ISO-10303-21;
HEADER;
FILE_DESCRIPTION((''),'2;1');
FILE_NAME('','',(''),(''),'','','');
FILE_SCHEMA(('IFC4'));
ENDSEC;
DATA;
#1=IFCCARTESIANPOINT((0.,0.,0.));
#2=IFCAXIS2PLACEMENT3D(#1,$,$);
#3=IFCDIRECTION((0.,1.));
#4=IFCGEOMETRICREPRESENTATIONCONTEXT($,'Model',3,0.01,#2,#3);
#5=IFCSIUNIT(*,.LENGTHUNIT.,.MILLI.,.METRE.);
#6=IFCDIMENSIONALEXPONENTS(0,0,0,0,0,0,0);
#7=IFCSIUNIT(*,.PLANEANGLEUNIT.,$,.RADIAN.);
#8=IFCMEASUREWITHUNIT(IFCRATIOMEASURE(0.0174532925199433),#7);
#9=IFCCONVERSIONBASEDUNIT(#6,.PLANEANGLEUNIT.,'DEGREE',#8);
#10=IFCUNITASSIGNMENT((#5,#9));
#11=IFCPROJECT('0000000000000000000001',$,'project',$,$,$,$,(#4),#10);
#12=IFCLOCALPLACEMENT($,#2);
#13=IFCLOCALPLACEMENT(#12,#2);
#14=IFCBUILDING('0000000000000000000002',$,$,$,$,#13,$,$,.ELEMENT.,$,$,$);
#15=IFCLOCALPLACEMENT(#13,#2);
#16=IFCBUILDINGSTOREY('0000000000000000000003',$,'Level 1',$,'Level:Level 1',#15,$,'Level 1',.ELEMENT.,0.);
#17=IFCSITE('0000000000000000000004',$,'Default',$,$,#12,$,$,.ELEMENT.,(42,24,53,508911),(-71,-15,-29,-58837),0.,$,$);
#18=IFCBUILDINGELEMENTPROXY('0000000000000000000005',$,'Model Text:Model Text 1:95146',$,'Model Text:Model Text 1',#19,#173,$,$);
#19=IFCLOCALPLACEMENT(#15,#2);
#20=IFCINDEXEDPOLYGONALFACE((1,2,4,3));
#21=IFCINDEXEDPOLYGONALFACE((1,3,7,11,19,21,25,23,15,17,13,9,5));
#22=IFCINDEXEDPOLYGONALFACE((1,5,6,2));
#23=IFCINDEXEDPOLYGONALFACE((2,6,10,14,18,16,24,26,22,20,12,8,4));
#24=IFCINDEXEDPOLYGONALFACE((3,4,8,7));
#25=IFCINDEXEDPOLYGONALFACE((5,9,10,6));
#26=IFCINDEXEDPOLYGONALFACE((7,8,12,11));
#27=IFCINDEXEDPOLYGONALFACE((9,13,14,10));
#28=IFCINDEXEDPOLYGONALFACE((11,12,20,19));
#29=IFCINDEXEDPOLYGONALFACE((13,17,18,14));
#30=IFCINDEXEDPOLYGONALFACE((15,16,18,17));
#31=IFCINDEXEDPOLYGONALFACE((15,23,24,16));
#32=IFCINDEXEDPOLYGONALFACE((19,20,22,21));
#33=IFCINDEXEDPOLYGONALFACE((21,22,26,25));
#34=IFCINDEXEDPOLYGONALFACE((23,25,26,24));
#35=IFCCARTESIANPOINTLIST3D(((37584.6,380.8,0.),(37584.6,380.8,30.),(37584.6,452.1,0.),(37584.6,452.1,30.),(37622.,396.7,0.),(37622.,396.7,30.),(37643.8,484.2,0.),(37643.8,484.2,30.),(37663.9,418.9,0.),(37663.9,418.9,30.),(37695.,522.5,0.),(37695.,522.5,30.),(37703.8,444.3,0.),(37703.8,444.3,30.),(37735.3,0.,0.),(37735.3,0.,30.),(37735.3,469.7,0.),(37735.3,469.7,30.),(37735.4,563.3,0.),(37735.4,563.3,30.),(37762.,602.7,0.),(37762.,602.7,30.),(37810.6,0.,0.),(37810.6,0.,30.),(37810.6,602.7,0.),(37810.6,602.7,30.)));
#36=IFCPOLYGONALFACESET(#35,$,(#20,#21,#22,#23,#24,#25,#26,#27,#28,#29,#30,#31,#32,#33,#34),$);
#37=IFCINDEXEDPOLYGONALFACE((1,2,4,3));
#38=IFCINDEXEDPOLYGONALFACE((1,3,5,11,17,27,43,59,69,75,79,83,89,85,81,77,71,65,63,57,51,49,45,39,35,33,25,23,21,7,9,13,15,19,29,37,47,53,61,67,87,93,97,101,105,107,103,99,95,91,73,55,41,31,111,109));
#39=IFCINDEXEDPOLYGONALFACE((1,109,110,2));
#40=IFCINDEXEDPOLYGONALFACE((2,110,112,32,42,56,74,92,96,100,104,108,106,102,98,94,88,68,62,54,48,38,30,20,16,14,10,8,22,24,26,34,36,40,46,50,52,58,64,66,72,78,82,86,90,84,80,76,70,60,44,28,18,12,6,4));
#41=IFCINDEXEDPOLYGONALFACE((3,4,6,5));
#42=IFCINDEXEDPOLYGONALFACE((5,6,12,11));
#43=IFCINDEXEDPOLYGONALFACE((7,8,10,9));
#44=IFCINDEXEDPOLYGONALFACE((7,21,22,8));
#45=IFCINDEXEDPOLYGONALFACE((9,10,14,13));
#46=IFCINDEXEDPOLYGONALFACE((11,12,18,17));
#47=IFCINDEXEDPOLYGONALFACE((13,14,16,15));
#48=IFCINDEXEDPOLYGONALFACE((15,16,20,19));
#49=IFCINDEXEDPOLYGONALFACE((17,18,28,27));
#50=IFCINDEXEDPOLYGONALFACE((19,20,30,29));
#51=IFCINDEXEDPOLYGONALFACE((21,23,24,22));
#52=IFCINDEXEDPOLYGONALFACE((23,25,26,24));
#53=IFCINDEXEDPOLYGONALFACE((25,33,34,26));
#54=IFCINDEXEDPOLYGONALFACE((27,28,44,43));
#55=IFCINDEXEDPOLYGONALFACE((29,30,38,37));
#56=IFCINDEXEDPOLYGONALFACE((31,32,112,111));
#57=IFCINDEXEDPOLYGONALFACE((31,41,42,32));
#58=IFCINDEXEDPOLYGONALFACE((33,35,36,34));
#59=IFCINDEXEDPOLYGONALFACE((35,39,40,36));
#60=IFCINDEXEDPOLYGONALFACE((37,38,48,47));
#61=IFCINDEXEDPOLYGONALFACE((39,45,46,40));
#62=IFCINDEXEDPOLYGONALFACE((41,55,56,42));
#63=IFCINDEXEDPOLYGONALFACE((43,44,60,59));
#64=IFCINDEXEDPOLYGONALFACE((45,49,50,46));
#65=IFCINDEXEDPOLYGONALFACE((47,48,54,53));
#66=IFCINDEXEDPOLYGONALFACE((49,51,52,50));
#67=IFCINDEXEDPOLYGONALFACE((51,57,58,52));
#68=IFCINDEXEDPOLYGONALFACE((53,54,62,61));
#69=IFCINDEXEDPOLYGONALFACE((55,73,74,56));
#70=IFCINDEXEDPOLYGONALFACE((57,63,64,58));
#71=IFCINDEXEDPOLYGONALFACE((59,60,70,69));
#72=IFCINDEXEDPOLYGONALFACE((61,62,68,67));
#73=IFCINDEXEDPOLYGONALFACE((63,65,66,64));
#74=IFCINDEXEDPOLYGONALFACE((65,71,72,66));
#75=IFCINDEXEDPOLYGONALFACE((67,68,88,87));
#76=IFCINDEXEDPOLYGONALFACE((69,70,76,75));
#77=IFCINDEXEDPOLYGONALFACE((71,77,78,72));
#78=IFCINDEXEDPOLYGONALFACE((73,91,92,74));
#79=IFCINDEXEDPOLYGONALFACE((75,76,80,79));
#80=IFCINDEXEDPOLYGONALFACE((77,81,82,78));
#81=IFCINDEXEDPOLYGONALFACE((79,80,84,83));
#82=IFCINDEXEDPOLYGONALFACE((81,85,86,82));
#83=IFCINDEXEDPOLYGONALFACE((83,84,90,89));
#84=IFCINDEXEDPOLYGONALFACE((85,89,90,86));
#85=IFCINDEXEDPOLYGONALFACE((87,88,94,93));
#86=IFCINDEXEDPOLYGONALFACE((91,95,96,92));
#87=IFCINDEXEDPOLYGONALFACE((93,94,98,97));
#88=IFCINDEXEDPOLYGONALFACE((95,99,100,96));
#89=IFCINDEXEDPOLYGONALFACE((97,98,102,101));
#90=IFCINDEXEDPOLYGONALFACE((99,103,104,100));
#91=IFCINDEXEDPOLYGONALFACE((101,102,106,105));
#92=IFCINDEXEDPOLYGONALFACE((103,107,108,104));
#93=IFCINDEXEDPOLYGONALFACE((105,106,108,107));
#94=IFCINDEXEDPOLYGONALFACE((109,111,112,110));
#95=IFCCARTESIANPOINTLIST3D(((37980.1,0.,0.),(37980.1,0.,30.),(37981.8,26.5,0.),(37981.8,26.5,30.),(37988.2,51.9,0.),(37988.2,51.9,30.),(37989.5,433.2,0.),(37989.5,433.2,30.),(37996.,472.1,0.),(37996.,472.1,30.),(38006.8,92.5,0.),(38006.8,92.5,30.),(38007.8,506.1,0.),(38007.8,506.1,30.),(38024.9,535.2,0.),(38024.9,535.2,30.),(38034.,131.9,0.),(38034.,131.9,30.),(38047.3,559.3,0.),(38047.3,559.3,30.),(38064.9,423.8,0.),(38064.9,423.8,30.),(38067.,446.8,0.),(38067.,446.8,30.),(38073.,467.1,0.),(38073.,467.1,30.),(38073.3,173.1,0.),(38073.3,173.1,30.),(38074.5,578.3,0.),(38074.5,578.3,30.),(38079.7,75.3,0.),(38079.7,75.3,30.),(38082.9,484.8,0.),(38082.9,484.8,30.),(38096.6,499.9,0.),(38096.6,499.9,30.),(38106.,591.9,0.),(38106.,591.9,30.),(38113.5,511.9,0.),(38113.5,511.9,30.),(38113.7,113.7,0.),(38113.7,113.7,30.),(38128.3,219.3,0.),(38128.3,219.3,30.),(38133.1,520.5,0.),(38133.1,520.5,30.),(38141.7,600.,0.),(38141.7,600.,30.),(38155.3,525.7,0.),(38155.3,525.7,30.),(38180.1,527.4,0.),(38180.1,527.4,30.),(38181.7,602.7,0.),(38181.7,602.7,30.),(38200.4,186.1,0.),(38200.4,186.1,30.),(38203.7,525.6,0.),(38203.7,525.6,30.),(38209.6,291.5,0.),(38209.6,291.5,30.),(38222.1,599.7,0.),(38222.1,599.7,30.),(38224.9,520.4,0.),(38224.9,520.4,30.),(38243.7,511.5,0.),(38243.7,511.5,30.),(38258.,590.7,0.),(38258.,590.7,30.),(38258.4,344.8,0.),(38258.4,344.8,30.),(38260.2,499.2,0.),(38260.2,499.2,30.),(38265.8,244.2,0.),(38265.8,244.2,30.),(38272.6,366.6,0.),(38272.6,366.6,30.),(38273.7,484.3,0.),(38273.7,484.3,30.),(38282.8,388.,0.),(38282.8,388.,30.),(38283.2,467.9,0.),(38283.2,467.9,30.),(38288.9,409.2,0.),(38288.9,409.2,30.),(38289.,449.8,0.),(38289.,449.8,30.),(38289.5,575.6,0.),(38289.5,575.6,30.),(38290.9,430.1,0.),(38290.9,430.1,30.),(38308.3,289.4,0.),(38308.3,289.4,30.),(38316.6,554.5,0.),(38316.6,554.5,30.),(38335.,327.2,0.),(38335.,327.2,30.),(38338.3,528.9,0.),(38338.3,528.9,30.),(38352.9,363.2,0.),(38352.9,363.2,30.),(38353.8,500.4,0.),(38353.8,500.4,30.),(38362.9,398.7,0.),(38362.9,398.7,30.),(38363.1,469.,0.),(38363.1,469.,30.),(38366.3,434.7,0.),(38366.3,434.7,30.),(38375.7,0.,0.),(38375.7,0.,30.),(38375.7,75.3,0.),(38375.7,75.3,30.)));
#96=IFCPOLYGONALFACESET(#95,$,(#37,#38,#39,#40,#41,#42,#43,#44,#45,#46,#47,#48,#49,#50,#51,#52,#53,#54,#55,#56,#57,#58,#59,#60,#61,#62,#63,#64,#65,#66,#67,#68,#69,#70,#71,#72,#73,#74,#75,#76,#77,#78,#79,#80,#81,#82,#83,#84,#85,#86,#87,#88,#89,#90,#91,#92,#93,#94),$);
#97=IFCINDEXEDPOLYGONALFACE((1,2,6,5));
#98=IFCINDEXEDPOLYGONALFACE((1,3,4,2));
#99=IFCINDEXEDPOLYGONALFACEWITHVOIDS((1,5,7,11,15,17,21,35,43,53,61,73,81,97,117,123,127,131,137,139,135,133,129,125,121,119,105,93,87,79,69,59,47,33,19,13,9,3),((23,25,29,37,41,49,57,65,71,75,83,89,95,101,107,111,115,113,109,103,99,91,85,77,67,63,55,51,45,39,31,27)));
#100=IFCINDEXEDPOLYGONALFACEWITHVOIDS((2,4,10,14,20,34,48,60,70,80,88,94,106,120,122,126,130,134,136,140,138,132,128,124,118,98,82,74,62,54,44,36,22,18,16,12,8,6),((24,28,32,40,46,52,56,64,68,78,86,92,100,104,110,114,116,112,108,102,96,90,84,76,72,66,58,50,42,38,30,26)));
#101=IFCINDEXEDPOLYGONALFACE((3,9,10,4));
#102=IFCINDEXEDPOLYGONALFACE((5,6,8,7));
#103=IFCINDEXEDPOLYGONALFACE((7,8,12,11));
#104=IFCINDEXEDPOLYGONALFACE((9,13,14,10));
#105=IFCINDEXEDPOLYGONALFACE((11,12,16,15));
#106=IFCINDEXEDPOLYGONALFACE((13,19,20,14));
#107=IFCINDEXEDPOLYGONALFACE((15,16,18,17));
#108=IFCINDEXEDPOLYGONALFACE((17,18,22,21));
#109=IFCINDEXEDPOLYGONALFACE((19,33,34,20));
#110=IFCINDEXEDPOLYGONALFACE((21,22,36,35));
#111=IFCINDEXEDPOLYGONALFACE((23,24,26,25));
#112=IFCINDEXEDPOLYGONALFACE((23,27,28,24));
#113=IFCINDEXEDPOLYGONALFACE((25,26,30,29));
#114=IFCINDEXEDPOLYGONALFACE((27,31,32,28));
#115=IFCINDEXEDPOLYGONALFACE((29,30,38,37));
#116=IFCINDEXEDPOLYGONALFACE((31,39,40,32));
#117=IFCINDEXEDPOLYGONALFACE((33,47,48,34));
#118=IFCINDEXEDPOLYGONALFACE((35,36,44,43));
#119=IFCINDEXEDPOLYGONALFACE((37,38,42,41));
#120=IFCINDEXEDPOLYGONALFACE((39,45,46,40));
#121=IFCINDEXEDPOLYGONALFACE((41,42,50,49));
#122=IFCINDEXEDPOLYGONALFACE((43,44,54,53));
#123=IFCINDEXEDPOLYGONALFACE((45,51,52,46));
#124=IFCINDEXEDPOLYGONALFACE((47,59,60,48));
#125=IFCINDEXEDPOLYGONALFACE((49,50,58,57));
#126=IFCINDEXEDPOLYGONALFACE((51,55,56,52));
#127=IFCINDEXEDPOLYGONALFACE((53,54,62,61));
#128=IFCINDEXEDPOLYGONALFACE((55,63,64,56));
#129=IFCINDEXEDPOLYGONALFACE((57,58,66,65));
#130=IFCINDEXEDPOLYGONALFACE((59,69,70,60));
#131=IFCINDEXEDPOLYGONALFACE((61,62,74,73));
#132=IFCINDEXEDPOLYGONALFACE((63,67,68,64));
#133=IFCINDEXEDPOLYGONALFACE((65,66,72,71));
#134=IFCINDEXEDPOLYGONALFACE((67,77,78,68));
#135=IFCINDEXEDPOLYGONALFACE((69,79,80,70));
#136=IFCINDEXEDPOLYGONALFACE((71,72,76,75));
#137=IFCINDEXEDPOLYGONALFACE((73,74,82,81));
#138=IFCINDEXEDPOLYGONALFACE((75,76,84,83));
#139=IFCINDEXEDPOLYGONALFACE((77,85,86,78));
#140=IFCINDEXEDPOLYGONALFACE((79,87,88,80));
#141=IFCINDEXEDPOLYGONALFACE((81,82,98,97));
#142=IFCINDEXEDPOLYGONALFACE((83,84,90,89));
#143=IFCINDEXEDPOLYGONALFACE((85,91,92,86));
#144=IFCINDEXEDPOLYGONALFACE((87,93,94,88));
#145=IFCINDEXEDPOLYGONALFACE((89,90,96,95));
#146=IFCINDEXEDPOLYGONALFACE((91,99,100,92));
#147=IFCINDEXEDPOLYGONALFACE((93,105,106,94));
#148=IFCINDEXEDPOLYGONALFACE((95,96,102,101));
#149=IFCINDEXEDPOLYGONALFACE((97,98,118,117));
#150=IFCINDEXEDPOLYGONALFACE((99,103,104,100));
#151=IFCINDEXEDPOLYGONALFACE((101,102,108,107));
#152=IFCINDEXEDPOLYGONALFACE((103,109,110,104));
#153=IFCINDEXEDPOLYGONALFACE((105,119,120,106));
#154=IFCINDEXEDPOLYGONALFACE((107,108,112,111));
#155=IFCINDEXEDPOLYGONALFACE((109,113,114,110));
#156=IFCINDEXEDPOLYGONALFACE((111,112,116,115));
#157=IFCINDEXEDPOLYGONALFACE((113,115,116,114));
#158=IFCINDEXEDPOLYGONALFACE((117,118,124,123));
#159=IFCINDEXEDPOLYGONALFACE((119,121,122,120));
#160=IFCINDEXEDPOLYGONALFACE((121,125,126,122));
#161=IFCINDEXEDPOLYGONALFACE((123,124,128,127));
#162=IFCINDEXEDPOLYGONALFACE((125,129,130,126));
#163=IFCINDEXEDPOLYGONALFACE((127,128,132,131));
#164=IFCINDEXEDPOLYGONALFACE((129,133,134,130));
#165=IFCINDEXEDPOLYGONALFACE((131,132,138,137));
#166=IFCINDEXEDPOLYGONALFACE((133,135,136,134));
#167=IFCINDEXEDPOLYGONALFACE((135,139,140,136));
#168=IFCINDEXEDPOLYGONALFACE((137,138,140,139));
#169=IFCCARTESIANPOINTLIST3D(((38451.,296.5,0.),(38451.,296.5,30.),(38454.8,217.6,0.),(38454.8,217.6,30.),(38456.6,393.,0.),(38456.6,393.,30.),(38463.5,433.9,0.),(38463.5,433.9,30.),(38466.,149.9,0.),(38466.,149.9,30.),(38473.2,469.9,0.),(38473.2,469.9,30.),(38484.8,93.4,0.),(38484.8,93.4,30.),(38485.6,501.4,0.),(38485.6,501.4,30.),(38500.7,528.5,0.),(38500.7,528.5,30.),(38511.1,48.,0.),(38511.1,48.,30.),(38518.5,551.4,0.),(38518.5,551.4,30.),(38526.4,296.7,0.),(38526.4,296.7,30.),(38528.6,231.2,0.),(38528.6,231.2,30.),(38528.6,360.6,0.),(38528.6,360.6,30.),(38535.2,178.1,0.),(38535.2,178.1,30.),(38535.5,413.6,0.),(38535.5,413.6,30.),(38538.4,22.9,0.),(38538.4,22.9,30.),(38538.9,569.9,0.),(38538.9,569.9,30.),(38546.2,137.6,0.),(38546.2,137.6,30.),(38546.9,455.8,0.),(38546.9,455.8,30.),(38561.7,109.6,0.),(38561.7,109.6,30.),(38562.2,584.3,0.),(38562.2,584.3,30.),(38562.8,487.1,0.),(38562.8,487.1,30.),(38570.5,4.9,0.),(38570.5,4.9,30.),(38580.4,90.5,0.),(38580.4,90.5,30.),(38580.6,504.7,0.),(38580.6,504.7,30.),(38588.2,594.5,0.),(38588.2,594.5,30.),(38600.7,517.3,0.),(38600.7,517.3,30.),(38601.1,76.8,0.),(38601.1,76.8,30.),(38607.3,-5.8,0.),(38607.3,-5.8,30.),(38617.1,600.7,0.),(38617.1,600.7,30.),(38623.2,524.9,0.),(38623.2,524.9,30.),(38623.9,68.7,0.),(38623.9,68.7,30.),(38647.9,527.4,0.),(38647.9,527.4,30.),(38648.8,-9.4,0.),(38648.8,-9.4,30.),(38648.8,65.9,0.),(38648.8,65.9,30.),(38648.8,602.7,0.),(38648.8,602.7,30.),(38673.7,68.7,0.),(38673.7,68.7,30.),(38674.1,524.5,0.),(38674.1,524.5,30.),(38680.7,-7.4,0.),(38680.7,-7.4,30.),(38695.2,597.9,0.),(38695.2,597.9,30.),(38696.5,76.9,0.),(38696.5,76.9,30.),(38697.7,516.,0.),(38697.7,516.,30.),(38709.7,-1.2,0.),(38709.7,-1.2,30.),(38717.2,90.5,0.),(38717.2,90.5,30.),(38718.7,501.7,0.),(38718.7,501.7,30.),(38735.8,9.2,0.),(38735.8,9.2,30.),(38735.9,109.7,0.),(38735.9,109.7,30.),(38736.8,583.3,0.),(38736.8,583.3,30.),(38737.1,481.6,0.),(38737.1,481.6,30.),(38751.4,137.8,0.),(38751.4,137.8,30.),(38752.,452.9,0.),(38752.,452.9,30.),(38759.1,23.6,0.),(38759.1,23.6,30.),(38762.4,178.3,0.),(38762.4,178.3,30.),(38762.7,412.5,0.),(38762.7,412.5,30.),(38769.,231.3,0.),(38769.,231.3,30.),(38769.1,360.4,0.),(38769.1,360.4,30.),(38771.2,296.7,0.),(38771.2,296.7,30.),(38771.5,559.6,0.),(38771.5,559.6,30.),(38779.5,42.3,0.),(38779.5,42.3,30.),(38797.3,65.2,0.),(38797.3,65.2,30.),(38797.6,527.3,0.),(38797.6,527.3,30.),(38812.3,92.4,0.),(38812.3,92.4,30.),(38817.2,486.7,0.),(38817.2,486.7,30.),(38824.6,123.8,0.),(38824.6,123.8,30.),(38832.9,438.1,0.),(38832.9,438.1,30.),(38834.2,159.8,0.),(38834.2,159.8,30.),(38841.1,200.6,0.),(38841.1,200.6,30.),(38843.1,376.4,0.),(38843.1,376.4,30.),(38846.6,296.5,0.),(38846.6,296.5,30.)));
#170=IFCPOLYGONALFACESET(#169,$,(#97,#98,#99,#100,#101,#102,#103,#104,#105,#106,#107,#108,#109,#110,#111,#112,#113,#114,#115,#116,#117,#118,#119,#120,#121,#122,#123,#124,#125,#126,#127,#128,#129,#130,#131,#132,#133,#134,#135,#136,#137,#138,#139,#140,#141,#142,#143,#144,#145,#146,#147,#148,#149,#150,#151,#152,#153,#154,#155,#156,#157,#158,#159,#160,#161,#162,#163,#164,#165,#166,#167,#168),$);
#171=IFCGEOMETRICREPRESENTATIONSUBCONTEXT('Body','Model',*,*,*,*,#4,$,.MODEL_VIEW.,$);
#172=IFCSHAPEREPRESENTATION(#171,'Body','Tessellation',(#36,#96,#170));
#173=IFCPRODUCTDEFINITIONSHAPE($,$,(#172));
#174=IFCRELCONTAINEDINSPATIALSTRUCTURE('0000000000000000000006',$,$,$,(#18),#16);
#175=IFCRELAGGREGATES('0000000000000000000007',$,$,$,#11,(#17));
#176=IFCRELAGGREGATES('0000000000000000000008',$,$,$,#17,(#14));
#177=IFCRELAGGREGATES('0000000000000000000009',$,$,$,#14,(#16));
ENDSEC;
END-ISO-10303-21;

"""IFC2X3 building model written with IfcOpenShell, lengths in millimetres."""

from ifc_helpers import new_model, entity, si_unit, converted_unit, direction, frame, origin, place, context, subcontext, project, spatial, polyline, outline, extrude, element, save


model = new_model("IFC2X3")

# Units and contexts
model_context = context("Model", 3, precision=0.01, world=origin(), true_north=direction((0.0, 1.0)))
body_context = subcontext(model_context, "Body", "Model", "MODEL_VIEW")
ifc_project = project(units=[si_unit("LENGTHUNIT", "METRE", prefix="MILLI"), converted_unit("PLANEANGLEUNIT", "DEGREE", entity("IfcRatioMeasure", 0.0174532925199433), si_unit("PLANEANGLEUNIT", "RADIAN"), dimensions=[0, 0, 0, 0, 0, 0, 0])], contexts=[model_context])

# Site, building, storey
site_placement = place(None, origin())
site = spatial("IfcSite", under=ifc_project, at=site_placement, Name="Default", CompositionType="ELEMENT", RefLatitude=(42, 24, 53, 508911), RefLongitude=(-71, -15, -29, -58837), RefElevation=0.0)
building_placement = place(site_placement, origin())
building = spatial("IfcBuilding", under=site, at=building_placement, CompositionType="ELEMENT")
storey_placement = place(building_placement, origin())
storey = spatial("IfcBuildingStorey", under=building, at=storey_placement, Name="Level 1", ObjectType="Level:Level 1", LongName="Level 1", CompositionType="ELEMENT", Elevation=0.0)

# Building element proxy
proxy_1_placement = place(storey_placement, origin())
element("IfcBuildingElementProxy", 1, at=proxy_1_placement, inside=storey, Name="Model Text:Model Text 1:95146", ObjectType="Model Text:Model Text 1", context=body_context, shape_type="SweptSolid", body=[
    extrude(outline(polyline([(-410.6, -111.6), (192.1, -111.6), (192.1, -63.1), (152.7, -36.4), (111.9, 4.0), (73.6, 55.2), (41.4, 114.4), (-29.8, 114.4), (-13.9, 77.0), (8.3, 35.1), (33.7, -4.8), (59.1, -36.3), (-410.6, -36.3), (-410.6, -111.6)])), frame((37699.0, 410.6, 0.0), z_axis=(0.0, 0.0, 1.0), x_axis=(0.0, 1.0, 0.0)), (0.0, 0.0, 1.0), 30.0),
    extrude(outline(polyline([(-190.2, -317.5), (-190.2, -392.8), (205.4, -392.8), (203.7, -366.3), (197.3, -340.9), (178.7, -300.3), (151.5, -260.9), (112.2, -219.7), (57.2, -173.6), (-24.1, -101.3), (-72.9, -48.0), (-87.1, -26.3), (-97.3, -4.8), (-103.4, 16.4), (-105.4, 37.3), (-103.5, 57.0), (-97.7, 75.0), (-88.2, 91.5), (-74.7, 106.4), (-58.2, 118.7), (-39.4, 127.5), (-18.2, 132.8), (5.4, 134.6), (30.2, 132.9), (52.4, 127.7), (72.0, 119.1), (88.9, 107.1), (102.6, 92.0), (112.5, 74.3), (118.5, 54.0), (120.6, 31.0), (196.0, 40.4), (189.5, 79.3), (177.7, 113.3), (160.6, 142.4), (138.2, 166.5), (111.0, 185.5), (79.5, 199.1), (43.8, 207.2), (3.8, 209.9), (-36.6, 206.9), (-72.5, 197.9), (-104.0, 182.8), (-131.1, 161.7), (-152.8, 136.1), (-168.3, 107.6), (-177.6, 76.2), (-180.8, 41.9), (-177.4, 5.8), (-167.4, -29.6), (-149.5, -65.6), (-122.8, -103.4), (-80.3, -148.6), (-14.9, -206.7), (71.8, -279.1), (105.8, -317.5), (-190.2, -317.5)])), frame((38185.5, 392.8, 0.0), z_axis=(0.0, 0.0, -1.0), x_axis=(-1.0, 0.0, 0.0)), (0.0, 0.0, -1.0), 30.0),
    extrude(outline(polyline([(-10.6, -198.7), (68.3, -198.7), (136.5, -190.7), (193.9, -174.7), (240.5, -150.6), (266.9, -124.4), (286.3, -93.2), (298.8, -57.0), (304.3, -15.7), (303.8, 16.2), (299.0, 45.5), (289.9, 72.1), (276.6, 96.0), (258.9, 117.3), (236.9, 136.2), (210.4, 152.5), (179.6, 166.3), (144.1, 177.6), (103.7, 186.3), (8.2, 196.4), (-71.8, 196.7), (-134.0, 189.4), (-183.3, 176.1), (-224.7, 158.4), (-258.2, 133.9), (-283.5, 100.3), (-300.1, 59.5), (-307.1, 13.4), (-306.6, -18.4), (-301.8, -47.5), (-292.8, -74.0), (-279.6, -97.9), (-262.0, -119.2), (-240.0, -138.1), (-213.6, -154.5), (-182.8, -168.4), (-147.3, -179.8), (-106.7, -188.6), (-10.6, -198.7)]), holes=[polyline([(-7.2, -123.5), (-71.0, -118.2), (-123.6, -108.8), (-165.2, -95.4), (-195.7, -78.0), (-212.4, -59.4), (-224.1, -38.7), (-230.6, -15.9), (-231.9, 8.9), (-227.8, 35.0), (-218.1, 58.1), (-202.8, 78.4), (-182.0, 95.8), (-152.6, 109.4), (-111.7, 118.1), (-59.4, 122.0), (4.4, 121.1), (69.6, 115.8), (122.2, 106.7), (162.2, 93.7), (189.5, 77.0), (207.7, 57.4), (220.4, 36.0), (227.5, 12.8), (229.1, -12.1), (225.2, -36.8), (215.9, -59.2), (201.3, -79.3), (181.4, -97.1), (152.6, -111.2), (111.6, -120.3), (58.3, -124.4), (-7.2, -123.5)])]), frame((38650.0, 295.3, 0.0), z_axis=(0.0, 0.0, 1.0), x_axis=(0.047515, -0.998871, 0.0)), (0.0, 0.0, 1.0), 30.0),
])

save(model, "model.ifc")
